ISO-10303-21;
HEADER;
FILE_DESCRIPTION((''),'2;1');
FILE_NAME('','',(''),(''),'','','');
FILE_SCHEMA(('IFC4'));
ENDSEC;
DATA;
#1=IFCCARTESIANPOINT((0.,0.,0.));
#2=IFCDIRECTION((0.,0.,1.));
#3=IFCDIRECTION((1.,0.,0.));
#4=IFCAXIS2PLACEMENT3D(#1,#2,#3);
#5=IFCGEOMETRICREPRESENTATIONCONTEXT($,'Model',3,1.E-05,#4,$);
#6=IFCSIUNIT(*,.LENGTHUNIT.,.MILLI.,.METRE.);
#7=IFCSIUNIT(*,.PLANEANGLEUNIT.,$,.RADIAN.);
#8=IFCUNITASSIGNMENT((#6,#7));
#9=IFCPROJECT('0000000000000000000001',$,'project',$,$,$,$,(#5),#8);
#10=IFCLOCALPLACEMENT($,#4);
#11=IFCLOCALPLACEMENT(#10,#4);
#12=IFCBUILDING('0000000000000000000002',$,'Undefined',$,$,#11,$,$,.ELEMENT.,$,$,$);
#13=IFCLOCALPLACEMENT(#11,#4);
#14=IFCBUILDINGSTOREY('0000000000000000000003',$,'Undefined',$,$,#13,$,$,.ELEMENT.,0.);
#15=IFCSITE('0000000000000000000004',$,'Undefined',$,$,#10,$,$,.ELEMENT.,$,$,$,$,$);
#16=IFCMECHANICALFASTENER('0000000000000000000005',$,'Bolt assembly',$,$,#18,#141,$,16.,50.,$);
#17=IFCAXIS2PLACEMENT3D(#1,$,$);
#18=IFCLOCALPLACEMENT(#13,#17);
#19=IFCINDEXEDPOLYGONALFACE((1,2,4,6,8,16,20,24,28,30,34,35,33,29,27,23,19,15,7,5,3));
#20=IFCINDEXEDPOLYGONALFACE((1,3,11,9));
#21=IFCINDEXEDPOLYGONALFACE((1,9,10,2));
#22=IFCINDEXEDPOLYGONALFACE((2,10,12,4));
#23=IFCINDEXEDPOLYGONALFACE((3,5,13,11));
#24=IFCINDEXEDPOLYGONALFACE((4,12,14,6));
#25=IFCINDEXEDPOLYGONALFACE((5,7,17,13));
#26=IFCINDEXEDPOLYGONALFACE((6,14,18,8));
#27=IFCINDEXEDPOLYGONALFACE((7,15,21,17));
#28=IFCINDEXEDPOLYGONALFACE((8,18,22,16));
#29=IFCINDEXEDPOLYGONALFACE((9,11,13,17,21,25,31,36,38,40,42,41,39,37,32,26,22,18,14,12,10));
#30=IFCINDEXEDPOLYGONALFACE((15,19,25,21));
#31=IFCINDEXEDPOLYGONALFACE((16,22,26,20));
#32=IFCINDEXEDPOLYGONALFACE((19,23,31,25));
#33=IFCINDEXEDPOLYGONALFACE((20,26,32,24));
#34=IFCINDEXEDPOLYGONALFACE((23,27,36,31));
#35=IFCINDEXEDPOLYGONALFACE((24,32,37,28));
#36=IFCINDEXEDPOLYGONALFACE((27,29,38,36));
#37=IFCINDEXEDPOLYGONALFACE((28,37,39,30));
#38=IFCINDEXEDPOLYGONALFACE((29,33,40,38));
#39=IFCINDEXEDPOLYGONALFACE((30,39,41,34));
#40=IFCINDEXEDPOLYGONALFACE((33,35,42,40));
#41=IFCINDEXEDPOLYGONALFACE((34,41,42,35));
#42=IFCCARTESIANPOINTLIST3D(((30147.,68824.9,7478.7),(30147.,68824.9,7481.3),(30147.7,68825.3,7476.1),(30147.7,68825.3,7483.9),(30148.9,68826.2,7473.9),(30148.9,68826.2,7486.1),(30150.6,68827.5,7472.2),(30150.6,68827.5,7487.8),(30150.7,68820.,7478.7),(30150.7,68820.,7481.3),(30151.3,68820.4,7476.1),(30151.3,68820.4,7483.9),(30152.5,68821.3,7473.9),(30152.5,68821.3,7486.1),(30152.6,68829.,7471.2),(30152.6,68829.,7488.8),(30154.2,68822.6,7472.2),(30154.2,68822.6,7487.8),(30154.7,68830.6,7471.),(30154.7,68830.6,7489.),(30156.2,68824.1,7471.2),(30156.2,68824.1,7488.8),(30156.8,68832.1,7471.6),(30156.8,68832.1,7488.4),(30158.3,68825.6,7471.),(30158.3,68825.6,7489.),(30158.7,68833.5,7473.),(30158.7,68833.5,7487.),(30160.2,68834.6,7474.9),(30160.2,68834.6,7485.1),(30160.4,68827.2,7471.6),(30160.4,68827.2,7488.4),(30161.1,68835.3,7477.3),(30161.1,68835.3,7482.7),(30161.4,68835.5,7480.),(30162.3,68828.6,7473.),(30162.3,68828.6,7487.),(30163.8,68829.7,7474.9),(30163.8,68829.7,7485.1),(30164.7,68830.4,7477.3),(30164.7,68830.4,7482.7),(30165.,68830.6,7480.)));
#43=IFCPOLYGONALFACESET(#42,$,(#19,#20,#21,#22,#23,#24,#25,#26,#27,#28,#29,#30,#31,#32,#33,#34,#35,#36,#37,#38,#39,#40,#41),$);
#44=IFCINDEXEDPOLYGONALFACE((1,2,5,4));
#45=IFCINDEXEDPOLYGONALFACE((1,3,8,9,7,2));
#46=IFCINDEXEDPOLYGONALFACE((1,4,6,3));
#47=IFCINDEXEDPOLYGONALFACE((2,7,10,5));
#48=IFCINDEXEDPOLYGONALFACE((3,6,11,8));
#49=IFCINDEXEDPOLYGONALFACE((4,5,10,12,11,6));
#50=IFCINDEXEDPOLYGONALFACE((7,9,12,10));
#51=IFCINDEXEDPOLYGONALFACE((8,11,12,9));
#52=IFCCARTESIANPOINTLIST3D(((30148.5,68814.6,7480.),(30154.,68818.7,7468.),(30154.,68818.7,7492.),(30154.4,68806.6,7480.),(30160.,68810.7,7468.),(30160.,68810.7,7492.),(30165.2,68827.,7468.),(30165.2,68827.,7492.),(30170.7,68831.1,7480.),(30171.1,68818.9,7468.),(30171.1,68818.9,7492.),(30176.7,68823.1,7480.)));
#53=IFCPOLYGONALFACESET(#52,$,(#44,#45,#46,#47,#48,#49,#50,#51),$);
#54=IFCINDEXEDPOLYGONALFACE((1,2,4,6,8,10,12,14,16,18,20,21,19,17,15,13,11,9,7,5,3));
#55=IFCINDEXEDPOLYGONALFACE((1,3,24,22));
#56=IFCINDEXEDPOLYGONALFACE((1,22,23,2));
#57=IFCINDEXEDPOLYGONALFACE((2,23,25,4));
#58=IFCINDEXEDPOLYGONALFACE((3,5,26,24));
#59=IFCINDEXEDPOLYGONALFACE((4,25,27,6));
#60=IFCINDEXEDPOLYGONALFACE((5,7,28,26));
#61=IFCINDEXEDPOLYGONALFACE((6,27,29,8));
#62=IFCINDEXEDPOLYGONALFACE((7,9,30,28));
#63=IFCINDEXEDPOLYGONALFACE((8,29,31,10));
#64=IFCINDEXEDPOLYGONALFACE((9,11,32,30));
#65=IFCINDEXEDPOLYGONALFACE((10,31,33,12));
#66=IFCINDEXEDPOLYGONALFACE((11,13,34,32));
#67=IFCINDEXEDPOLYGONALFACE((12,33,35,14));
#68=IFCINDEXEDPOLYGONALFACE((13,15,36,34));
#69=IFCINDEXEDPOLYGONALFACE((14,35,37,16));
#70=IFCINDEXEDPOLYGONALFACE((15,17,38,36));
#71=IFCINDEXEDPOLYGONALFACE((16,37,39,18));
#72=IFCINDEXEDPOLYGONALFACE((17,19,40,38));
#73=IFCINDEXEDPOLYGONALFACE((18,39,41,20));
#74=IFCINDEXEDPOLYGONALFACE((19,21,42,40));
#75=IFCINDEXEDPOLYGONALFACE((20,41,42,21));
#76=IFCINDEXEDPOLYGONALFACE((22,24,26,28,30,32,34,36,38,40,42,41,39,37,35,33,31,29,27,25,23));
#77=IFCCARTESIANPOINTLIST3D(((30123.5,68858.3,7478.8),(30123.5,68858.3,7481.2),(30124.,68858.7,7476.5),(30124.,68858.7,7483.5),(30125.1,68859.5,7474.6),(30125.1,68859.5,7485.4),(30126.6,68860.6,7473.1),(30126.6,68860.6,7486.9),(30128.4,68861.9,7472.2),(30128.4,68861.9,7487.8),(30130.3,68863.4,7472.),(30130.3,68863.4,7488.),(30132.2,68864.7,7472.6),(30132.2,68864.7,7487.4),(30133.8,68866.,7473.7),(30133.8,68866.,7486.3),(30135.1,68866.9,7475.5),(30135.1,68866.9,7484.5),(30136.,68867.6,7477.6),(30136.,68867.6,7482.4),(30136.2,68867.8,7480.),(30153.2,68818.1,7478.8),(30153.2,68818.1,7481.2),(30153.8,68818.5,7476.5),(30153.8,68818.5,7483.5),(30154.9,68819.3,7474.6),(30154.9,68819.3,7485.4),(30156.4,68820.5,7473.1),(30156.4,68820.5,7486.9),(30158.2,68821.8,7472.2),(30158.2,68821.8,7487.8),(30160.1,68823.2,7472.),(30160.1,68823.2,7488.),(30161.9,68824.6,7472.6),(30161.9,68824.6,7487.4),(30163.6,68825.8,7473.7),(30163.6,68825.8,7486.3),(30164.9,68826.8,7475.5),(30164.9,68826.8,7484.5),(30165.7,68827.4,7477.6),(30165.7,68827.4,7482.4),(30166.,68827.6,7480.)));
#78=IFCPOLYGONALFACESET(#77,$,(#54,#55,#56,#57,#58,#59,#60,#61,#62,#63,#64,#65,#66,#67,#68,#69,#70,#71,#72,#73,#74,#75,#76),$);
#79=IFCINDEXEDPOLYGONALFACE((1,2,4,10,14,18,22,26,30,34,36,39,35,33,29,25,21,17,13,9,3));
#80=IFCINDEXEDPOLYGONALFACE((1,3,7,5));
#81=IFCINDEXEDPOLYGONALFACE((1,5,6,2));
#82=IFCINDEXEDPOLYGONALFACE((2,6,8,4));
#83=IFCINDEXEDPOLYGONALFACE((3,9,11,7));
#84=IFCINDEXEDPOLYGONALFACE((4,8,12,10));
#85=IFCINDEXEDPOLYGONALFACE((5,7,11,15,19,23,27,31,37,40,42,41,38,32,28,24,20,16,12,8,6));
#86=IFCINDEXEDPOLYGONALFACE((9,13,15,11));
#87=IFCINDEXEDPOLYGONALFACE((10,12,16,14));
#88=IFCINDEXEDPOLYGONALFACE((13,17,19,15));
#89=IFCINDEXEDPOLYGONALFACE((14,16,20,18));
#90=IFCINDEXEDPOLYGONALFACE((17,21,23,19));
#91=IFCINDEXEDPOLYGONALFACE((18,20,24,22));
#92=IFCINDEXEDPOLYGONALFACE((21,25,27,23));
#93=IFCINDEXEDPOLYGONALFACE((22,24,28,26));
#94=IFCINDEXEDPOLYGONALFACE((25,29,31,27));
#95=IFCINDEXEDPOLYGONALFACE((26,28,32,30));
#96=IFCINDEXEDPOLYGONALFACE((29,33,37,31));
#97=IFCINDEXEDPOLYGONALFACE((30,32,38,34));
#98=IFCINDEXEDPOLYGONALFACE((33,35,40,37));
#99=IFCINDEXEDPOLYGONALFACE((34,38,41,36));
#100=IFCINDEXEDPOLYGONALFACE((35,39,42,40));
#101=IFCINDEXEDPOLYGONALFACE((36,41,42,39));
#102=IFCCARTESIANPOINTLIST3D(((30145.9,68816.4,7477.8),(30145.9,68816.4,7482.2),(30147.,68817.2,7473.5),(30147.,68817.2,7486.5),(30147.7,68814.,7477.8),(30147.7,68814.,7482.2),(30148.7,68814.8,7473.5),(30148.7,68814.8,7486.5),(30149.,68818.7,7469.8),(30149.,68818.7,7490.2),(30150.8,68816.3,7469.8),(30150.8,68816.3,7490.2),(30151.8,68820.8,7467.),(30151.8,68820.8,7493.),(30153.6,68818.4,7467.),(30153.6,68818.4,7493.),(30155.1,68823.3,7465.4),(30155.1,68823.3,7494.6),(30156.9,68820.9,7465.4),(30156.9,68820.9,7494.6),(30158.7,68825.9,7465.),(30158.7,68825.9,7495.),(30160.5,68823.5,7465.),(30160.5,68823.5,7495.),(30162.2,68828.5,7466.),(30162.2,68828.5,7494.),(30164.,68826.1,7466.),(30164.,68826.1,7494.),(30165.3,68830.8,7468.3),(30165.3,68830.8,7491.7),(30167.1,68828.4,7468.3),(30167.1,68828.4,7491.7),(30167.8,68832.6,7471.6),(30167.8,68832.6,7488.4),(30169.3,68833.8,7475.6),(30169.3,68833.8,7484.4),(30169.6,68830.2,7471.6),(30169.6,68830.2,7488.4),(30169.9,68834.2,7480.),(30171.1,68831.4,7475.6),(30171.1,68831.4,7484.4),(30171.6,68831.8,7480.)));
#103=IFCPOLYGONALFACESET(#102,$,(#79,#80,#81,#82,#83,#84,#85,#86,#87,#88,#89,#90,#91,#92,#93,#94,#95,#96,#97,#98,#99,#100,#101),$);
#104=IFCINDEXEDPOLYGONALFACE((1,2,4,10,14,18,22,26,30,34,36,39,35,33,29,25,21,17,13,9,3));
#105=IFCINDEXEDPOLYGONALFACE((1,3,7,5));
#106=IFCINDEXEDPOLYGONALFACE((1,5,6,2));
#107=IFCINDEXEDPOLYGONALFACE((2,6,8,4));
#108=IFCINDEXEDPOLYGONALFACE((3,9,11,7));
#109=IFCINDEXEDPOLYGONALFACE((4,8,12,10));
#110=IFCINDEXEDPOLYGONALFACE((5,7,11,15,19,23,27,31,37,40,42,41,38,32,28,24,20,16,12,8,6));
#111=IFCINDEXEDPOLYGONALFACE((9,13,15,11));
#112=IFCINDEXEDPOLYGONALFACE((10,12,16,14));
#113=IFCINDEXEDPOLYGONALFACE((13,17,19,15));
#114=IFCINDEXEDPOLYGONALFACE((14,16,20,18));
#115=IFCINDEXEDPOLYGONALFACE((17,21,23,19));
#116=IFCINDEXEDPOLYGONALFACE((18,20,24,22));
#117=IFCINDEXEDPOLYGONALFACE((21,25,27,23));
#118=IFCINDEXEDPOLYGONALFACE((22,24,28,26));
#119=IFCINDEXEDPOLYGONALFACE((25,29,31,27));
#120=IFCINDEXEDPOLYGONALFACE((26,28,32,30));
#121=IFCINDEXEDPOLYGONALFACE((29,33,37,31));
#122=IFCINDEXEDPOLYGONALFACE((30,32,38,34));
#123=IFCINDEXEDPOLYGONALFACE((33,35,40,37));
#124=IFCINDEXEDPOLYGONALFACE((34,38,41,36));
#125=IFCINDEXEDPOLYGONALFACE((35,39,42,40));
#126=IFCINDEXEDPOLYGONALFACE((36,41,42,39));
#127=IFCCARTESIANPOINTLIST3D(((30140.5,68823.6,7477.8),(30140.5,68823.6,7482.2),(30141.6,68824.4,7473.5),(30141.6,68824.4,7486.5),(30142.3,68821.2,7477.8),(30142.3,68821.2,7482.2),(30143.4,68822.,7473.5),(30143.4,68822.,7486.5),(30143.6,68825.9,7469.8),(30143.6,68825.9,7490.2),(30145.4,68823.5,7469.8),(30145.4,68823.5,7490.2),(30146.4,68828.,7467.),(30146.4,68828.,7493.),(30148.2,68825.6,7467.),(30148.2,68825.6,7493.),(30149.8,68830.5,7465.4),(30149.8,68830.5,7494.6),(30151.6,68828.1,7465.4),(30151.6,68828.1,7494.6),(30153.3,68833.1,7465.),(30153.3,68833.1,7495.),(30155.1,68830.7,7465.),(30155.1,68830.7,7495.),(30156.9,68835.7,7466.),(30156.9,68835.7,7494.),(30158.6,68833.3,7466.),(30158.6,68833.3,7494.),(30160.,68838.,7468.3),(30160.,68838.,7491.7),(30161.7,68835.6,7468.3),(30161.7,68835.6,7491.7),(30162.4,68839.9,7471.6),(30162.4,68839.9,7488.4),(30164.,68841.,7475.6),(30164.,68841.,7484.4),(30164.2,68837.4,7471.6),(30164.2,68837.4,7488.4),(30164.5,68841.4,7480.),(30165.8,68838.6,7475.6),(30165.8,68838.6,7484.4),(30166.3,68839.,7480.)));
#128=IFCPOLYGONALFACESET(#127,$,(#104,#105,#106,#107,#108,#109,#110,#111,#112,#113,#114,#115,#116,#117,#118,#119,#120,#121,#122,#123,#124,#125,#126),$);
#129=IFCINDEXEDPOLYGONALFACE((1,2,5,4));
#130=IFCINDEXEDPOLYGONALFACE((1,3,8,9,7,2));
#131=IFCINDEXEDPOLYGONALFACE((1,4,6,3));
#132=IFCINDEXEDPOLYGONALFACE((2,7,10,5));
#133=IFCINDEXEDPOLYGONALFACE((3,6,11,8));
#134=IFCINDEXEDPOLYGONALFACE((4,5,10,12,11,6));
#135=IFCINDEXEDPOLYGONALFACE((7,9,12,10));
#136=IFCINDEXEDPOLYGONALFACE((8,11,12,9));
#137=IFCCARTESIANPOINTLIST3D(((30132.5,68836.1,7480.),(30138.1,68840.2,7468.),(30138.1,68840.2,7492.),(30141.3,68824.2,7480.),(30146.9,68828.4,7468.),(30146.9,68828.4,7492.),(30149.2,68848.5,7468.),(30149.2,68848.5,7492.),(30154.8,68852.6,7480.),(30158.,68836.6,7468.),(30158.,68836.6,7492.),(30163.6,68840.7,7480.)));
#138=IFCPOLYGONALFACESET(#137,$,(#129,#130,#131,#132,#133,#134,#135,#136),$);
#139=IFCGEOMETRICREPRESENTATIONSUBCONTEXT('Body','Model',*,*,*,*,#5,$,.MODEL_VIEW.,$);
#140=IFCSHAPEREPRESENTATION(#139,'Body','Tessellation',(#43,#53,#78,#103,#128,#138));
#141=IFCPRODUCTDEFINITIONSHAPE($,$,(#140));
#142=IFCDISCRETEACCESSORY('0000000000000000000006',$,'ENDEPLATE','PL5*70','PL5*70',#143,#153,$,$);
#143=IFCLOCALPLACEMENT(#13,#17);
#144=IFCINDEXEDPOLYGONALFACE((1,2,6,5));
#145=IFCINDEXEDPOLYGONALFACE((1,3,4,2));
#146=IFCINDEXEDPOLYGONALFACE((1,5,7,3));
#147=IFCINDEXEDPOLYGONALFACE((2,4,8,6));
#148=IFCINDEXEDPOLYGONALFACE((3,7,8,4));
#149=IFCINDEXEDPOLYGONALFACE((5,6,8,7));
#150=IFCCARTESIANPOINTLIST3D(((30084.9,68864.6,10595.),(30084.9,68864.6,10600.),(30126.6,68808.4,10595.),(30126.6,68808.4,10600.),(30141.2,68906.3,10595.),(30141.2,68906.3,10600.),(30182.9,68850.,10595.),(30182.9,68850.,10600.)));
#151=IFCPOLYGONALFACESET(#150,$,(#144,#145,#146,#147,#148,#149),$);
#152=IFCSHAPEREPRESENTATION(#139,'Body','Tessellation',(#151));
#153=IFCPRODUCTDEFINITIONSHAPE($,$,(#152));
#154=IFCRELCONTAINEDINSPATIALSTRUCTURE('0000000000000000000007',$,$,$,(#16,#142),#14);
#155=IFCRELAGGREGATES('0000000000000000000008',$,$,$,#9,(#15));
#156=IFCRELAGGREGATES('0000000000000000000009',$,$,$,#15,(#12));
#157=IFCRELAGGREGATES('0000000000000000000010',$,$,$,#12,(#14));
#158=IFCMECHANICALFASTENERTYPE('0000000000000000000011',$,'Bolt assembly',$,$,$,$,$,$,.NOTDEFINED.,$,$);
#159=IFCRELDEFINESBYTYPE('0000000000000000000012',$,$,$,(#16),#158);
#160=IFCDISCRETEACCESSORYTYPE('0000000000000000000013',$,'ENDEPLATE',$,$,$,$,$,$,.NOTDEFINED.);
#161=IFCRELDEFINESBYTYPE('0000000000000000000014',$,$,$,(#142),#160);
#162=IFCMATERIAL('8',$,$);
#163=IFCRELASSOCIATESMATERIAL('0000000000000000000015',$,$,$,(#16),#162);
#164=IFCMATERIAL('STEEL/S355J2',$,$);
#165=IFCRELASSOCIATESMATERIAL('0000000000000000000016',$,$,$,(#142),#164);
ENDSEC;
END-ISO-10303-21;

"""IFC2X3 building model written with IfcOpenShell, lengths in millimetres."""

from ifc_helpers import new_model, si_unit, frame, origin_with_axes, origin_2d_with_axis, place, context, subcontext, project, spatial, polyline, circle, outline, extrude, source, transform, mapped, material, type_object, element, save


model = new_model("IFC2X3")

# Units and contexts
model_context = context("Model", 3, precision=1e-05, world=origin_with_axes())
body_context = subcontext(model_context, "Body", "Model", "MODEL_VIEW")
ifc_project = project(units=[si_unit("LENGTHUNIT", "METRE", prefix="MILLI"), si_unit("PLANEANGLEUNIT", "RADIAN")], contexts=[model_context])

# Site, building, storey
site_placement = place(None, origin_with_axes())
site = spatial("IfcSite", under=ifc_project, at=site_placement, Name="Undefined", CompositionType="ELEMENT")
building_placement = place(site_placement, origin_with_axes())
building = spatial("IfcBuilding", under=site, at=building_placement, Name="Undefined", CompositionType="ELEMENT")
storey_placement = place(building_placement, origin_with_axes())
storey = spatial("IfcBuildingStorey", under=building, at=storey_placement, Name="Undefined", CompositionType="ELEMENT", Elevation=0.0)

# Shared definitions
ifc_material_1 = material(Name="STEEL/S355J2")

# Mechanical fastener
ifc_material_2 = material(Name="8")
mechanical_fastener_type = type_object("IfcMechanicalFastenerType", Name="Bolt assembly")
shared_shape_1 = source(origin_with_axes(), body_context, "Body", "SweptSolid", [
    extrude(circle(Radius=9.0, at=origin_2d_with_axis()), frame((0.0, 8.0, 0.0), z_axis=(0.0, 1.0, 0.0), x_axis=(1.0, 0.0, 0.0)), (0.0, 0.0, 1.0), 6.1),
    extrude(outline(polyline([(13.9, 0.0), (6.9, 12.0), (-6.9, 12.0), (-13.9, 0.0), (-6.9, -12.0), (6.9, -12.0), (13.9, 0.0)])), frame((0.0, -5.0, 0.0), z_axis=(0.0, 1.0, 0.0), x_axis=(1.0, 0.0, 0.0)), (0.0, 0.0, 1.0), 10.0),
    extrude(circle(Radius=8.0, at=origin_2d_with_axis()), frame((0.0, 5.0, 0.0), z_axis=(0.0, 1.0, 0.0), x_axis=(1.0, 0.0, 0.0)), (0.0, 0.0, 1.0), 50.0),
    extrude(circle(Radius=15.0, at=origin_2d_with_axis()), frame((0.0, 5.0, 0.0), z_axis=(0.0, 1.0, 0.0), x_axis=(1.0, 0.0, 0.0)), (0.0, 0.0, 1.0), 3.0),
    extrude(circle(Radius=15.0, at=origin_2d_with_axis()), frame((0.0, 14.0, 0.0), z_axis=(0.0, 1.0, 0.0), x_axis=(1.0, 0.0, 0.0)), (0.0, 0.0, 1.0), 3.0),
    extrude(outline(polyline([(13.9, 0.0), (6.9, 12.0), (-6.9, 12.0), (-13.9, 0.0), (-6.9, -12.0), (6.9, -12.0), (13.9, 0.0)])), frame((0.0, 17.0, 0.0), z_axis=(0.0, 1.0, 0.0), x_axis=(1.0, 0.0, 0.0)), (0.0, 0.0, 1.0), 14.8),
])
for number, where, z_axis, x_axis, name in (
    (1, (30162.6, 68818.8, 7480.0), (0.0, 0.0, 1.0), (0.803401, 0.595438, 0.0), "Bolt assembly"),
):
    element("IfcMechanicalFastener", number, at=place(storey_placement, frame(where, z_axis=z_axis, x_axis=x_axis)), inside=storey, type_object=mechanical_fastener_type, material=ifc_material_2, Name=name, NominalDiameter=16.0, NominalLength=50.0, context=body_context, shape_type="MappedRepresentation", body=[
        mapped(shared_shape_1, transform((0.0, 0.0, 0.0))),
    ])

# Discrete accessory
discrete_accessory_type = type_object("IfcDiscreteAccessoryType", Name="ENDEPLATE")
discrete_accessory_placement = place(storey_placement, frame((30113.1, 68885.4, 10597.5), z_axis=(0.0, 0.0, -1.0), x_axis=(0.595445, -0.803396, 0.0)))
element("IfcDiscreteAccessory", 2, at=discrete_accessory_placement, inside=storey, type_object=discrete_accessory_type, material=ifc_material_1, Name="ENDEPLATE", Description="PL5*70", ObjectType="PL5*70", context=body_context, shape_type="SweptSolid", body=[
    extrude(outline(polyline([(0.0, 35.0), (70.0, 35.0), (70.0, -35.0), (0.0, -35.0), (0.0, 35.0)])), frame((0.0, 0.0, -2.5), z_axis=(0.0, 0.0, 1.0), x_axis=(1.0, 0.0, 0.0)), (0.0, 0.0, 1.0), 5.0),
])

save(model, "model.ifc")
